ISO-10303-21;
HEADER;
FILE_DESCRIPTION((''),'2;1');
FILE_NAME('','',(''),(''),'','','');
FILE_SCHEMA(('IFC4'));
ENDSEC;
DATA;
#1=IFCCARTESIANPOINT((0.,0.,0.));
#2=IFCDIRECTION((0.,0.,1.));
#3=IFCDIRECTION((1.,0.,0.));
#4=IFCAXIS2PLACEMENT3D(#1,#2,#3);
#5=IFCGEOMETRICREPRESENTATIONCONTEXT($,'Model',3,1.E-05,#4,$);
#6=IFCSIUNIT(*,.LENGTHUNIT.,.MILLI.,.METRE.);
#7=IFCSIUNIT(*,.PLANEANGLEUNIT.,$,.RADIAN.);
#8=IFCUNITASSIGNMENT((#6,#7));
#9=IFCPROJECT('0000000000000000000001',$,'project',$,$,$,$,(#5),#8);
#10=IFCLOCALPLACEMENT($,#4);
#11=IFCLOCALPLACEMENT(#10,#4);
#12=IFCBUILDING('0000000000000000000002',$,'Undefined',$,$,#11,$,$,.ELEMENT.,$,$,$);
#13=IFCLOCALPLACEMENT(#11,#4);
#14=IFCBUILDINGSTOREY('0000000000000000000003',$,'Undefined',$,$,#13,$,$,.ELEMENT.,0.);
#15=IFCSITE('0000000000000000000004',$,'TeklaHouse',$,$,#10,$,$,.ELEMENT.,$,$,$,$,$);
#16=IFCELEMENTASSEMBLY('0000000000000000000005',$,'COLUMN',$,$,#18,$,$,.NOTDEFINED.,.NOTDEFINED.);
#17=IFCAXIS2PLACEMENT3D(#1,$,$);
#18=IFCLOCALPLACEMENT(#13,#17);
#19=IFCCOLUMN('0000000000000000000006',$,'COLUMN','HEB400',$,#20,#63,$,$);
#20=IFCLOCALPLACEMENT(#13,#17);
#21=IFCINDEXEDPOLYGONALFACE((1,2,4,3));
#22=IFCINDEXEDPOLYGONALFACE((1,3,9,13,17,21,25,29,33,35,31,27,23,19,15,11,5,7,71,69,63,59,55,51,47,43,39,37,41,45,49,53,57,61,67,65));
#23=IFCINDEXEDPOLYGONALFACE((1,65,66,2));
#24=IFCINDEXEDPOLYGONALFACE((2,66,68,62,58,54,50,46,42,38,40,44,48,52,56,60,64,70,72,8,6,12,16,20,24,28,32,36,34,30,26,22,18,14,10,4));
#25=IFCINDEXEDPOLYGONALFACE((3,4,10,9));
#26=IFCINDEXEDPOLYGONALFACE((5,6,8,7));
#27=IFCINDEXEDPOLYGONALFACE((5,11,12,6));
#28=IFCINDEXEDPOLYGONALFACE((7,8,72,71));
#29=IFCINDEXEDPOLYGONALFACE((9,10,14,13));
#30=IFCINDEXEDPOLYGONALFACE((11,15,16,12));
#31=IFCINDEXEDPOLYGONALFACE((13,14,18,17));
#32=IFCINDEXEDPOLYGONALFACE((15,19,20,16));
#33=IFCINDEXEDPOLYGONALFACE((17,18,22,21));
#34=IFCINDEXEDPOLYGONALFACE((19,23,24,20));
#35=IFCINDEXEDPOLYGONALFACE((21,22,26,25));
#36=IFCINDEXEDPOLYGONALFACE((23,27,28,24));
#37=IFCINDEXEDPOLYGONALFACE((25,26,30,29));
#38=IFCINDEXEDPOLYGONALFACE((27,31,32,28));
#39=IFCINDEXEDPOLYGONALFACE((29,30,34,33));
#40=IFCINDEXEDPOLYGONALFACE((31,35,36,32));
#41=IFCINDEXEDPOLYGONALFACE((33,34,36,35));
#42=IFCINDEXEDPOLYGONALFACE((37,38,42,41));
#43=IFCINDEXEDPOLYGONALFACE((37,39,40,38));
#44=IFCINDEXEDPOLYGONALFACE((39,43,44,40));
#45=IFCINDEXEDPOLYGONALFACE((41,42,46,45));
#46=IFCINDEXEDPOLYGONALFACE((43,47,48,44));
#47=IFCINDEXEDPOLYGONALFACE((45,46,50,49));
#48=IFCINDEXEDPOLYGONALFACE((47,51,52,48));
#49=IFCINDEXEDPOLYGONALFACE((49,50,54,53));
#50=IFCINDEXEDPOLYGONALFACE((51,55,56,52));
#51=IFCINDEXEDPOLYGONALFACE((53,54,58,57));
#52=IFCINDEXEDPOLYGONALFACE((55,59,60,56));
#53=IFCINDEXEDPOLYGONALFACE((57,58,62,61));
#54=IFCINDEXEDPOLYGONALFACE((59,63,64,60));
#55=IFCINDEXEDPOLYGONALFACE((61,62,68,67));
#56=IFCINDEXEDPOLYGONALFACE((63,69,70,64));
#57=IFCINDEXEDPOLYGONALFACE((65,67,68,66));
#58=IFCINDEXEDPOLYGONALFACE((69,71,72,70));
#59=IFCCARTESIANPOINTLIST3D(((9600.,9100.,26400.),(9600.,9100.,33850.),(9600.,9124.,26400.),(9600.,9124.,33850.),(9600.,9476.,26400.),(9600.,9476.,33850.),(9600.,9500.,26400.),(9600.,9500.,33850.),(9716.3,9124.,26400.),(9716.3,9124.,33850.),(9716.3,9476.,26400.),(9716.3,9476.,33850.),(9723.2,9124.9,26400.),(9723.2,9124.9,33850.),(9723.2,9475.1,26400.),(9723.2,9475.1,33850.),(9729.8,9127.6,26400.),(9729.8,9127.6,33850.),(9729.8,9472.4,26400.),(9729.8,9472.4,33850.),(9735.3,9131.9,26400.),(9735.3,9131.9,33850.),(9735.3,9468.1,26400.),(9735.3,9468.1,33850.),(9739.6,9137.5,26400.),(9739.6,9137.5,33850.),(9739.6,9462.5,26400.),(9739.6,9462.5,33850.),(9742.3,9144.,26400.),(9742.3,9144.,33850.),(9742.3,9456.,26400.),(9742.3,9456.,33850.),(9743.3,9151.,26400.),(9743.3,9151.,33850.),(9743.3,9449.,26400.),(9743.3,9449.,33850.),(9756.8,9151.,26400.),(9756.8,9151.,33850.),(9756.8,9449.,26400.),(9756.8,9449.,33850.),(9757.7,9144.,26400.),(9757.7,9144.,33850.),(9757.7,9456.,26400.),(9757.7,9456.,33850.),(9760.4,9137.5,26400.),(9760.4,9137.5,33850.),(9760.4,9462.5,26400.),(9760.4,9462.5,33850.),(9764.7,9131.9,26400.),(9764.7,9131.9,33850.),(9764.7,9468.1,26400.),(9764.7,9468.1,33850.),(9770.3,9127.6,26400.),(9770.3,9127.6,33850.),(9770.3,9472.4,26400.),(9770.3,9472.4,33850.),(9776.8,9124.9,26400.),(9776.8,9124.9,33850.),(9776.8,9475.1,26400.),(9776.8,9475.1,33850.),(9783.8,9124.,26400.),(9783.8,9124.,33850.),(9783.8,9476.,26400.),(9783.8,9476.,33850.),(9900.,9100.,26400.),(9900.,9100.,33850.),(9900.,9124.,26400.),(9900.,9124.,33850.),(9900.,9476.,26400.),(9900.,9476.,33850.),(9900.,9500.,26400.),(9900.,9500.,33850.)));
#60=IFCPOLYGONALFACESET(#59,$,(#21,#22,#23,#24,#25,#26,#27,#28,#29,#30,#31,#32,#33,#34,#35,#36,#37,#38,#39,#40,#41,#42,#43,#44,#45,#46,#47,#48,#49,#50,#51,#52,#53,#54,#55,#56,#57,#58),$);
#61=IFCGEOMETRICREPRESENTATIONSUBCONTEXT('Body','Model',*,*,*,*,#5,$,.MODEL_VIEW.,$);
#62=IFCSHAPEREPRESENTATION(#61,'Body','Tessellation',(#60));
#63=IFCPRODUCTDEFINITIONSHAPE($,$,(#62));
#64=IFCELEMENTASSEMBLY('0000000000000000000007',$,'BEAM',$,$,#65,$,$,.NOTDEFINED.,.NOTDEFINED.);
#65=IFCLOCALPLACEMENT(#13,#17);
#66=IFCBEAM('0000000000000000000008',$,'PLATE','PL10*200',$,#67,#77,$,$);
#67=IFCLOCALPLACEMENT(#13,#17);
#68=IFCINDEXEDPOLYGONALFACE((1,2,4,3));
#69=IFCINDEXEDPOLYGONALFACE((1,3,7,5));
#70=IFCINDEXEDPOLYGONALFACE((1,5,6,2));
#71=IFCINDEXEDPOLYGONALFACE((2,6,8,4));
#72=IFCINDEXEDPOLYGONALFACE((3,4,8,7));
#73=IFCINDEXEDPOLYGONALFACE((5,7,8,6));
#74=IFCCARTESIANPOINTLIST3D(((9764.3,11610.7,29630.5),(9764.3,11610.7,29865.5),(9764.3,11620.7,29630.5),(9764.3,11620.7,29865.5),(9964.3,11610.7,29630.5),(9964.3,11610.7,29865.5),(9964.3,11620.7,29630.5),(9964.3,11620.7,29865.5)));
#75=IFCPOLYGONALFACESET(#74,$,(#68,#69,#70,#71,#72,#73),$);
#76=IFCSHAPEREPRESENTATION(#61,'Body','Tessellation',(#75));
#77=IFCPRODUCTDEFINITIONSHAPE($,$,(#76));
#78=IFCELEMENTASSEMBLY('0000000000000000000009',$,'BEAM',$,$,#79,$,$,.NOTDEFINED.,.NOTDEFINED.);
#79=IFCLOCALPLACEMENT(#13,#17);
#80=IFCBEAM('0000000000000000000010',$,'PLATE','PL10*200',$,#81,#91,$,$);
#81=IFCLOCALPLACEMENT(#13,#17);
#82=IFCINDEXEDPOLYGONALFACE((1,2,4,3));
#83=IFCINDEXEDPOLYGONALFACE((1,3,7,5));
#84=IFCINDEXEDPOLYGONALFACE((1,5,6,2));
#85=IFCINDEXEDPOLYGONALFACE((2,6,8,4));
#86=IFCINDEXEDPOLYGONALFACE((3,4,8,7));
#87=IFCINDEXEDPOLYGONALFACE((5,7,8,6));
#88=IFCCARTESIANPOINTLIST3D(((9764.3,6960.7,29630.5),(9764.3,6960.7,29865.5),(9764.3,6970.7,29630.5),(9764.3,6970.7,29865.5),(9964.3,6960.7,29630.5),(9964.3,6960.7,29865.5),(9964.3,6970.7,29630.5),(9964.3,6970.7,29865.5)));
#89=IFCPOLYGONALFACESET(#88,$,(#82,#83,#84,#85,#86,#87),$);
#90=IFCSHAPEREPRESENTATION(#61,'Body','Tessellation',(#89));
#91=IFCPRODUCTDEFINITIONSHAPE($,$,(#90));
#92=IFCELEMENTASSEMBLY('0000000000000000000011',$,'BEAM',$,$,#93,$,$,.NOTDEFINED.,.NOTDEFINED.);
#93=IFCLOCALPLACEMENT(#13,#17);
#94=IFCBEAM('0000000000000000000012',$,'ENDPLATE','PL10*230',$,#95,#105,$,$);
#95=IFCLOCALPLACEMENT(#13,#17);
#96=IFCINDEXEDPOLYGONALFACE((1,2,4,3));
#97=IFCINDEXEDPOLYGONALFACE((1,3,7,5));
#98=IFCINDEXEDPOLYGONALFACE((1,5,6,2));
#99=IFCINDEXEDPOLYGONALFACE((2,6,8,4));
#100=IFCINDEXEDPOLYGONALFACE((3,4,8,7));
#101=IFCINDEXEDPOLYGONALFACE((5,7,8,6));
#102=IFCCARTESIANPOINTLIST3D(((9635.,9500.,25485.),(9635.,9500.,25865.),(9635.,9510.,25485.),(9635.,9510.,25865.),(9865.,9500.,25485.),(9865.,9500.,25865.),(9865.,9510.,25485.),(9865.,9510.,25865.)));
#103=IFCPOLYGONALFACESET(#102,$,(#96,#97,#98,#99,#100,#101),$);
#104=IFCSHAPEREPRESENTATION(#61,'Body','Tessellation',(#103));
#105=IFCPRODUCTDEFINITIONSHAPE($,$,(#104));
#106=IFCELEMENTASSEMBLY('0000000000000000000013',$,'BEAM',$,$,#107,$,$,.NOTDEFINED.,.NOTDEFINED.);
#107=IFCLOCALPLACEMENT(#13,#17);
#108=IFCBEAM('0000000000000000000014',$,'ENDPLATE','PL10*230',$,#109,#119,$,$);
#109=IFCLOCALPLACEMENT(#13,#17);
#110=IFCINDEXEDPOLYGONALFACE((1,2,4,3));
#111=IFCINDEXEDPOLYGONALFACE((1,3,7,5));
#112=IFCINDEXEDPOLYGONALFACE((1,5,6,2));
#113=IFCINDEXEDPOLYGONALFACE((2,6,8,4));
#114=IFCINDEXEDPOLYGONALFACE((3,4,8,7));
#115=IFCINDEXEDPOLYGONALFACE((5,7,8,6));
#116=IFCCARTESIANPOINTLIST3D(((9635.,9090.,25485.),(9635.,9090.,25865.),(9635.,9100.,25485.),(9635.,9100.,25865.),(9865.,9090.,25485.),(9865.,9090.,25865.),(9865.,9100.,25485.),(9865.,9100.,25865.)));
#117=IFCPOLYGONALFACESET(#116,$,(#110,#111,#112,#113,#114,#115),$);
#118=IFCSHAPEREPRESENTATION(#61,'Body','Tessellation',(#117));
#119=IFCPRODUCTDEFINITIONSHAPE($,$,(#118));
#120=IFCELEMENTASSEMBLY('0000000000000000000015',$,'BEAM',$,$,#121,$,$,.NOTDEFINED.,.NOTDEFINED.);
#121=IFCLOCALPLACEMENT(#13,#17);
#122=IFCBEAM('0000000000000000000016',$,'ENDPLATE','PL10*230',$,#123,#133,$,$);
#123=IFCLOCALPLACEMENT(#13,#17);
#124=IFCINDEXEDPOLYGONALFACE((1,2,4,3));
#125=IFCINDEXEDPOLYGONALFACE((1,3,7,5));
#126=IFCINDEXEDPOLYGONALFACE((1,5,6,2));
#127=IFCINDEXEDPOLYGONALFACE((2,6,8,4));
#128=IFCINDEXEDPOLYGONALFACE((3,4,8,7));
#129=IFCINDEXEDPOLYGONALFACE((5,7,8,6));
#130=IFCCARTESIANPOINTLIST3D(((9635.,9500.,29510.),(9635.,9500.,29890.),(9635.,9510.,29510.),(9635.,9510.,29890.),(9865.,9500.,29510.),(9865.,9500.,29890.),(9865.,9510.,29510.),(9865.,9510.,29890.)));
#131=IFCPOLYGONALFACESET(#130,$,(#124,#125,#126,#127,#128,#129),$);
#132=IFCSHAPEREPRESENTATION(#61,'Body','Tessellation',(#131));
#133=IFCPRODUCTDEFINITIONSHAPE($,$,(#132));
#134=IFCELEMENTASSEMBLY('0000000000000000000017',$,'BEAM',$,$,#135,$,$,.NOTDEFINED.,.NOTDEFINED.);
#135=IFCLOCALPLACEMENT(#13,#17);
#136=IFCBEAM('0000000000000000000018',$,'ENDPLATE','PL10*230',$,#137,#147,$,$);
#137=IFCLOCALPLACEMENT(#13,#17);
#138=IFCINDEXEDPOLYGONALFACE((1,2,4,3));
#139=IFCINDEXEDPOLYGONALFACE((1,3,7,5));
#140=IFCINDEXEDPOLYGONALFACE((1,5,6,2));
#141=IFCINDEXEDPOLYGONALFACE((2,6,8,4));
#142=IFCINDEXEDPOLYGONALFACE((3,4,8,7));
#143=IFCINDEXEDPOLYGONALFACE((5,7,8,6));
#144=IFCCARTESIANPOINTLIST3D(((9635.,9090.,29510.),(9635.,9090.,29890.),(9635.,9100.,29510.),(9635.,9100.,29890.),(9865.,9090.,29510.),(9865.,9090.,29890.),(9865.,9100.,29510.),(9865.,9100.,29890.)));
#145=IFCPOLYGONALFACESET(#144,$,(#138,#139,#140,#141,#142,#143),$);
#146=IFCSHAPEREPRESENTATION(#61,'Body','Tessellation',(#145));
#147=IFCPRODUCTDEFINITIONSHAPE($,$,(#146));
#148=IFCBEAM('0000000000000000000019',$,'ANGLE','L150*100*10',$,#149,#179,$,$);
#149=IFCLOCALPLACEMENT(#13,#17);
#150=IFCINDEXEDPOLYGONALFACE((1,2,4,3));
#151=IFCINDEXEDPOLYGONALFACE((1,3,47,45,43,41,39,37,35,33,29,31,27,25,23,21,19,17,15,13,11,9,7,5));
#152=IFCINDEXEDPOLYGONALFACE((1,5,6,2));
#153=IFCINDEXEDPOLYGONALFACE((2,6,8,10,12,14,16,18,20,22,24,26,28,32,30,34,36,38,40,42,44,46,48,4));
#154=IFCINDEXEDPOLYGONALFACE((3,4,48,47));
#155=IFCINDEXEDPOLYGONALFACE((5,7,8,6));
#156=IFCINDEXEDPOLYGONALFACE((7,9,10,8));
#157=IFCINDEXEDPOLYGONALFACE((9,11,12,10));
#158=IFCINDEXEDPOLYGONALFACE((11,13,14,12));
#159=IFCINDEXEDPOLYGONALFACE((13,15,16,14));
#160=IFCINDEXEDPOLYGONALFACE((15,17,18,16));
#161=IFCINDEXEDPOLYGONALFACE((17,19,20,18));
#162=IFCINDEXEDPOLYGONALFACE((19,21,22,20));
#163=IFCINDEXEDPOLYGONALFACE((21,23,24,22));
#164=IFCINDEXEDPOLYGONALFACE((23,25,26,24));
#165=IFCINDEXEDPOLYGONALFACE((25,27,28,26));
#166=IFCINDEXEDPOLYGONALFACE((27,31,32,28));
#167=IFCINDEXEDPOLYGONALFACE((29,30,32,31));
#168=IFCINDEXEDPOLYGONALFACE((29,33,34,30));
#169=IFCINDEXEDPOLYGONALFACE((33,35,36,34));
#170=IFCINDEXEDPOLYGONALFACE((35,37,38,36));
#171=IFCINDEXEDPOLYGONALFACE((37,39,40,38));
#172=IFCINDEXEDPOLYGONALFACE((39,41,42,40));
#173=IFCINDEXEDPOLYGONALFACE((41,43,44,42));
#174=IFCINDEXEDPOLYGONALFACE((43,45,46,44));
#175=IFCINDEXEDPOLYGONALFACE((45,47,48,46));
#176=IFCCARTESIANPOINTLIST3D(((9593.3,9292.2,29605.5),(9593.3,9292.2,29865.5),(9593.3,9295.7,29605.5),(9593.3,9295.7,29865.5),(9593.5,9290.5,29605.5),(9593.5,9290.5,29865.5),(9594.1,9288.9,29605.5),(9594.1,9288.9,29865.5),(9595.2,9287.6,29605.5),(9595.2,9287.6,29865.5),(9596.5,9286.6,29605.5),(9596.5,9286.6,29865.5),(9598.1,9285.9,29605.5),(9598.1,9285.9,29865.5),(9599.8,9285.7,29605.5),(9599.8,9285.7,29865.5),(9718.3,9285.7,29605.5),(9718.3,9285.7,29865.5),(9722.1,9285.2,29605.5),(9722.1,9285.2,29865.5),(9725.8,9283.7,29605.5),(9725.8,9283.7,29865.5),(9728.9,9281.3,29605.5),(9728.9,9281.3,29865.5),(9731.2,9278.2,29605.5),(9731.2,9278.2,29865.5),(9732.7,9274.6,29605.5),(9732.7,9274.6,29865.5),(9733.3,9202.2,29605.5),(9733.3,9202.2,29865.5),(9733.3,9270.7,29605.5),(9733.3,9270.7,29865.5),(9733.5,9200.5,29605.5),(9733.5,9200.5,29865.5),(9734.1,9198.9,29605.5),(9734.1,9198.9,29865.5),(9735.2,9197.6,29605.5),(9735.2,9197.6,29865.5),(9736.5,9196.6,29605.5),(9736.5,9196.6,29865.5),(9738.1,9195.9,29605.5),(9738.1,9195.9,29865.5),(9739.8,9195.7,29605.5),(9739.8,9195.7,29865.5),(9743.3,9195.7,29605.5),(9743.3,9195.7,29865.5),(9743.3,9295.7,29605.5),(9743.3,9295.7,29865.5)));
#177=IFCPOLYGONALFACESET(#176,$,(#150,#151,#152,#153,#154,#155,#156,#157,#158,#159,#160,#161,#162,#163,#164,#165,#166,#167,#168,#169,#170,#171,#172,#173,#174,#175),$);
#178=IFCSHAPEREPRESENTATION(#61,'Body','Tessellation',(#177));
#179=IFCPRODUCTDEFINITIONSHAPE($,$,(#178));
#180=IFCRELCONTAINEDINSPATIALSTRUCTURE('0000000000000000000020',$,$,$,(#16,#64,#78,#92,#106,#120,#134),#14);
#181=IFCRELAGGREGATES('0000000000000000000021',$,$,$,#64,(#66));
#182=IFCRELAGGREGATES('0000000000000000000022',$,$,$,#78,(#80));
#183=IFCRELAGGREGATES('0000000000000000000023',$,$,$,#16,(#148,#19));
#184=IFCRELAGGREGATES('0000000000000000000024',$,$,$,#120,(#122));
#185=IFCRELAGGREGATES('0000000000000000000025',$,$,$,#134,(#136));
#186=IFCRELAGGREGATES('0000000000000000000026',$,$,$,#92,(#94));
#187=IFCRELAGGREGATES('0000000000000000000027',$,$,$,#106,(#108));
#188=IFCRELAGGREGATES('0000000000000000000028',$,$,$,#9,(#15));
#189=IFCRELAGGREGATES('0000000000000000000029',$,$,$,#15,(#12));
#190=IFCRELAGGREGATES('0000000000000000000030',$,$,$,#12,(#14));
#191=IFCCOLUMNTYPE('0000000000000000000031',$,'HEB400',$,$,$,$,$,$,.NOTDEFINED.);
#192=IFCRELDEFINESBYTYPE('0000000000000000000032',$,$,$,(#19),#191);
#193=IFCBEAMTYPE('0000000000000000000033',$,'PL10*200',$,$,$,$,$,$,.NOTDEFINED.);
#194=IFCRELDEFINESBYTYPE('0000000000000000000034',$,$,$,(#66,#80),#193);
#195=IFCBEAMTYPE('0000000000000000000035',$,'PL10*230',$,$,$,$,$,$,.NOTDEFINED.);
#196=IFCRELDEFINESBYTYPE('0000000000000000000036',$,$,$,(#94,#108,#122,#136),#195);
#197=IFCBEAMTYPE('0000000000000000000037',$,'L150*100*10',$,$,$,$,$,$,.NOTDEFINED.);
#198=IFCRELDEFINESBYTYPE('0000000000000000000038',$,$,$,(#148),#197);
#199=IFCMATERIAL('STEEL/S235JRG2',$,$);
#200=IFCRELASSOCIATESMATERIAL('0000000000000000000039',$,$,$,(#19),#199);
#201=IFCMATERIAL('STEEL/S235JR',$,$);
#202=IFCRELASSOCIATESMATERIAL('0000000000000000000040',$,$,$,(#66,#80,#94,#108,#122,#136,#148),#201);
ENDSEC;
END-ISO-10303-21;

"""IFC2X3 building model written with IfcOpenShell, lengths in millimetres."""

from ifc_helpers import new_model, si_unit, frame, origin_with_axes, origin_2d_with_axis, place, context, subcontext, project, spatial, rectangle, i_section, l_section, extrude, material, type_object, element, aggregate, save


model = new_model("IFC2X3")

# Units and contexts
model_context = context("Model", 3, precision=1e-05, world=origin_with_axes())
body_context = subcontext(model_context, "Body", "Model", "MODEL_VIEW")
ifc_project = project(units=[si_unit("LENGTHUNIT", "METRE", prefix="MILLI"), si_unit("PLANEANGLEUNIT", "RADIAN")], contexts=[model_context])

# Site, building, storey
site_placement = place(None, origin_with_axes())
site = spatial("IfcSite", under=ifc_project, at=site_placement, Name="TeklaHouse", CompositionType="ELEMENT")
building_placement = place(site_placement, origin_with_axes())
building = spatial("IfcBuilding", under=site, at=building_placement, Name="Undefined", CompositionType="ELEMENT")
storey_placement = place(building_placement, origin_with_axes())
storey = spatial("IfcBuildingStorey", under=building, at=storey_placement, Name="Undefined", CompositionType="ELEMENT", Elevation=0.0)

# Element assembly, column
assembly_1_placement = place(storey_placement, origin_with_axes())
assembly_1 = element("IfcElementAssembly", 1, at=assembly_1_placement, inside=storey, Name="COLUMN", AssemblyPlace="NOTDEFINED", PredefinedType="NOTDEFINED")
ifc_material_1 = material(Name="STEEL/S235JRG2")
column_type = type_object("IfcColumnType", Name="HEB400", PredefinedType="NOTDEFINED")
column_placement = place(assembly_1_placement, frame((9750.0, 9300.0, 26400.0), z_axis=(0.0, 0.0, 1.0), x_axis=(0.0, 1.0, 0.0)))
column = element("IfcColumn", 2, at=column_placement, type_object=column_type, material=ifc_material_1, Name="COLUMN", Description="HEB400", context=body_context, shape_type="SweptSolid", body=[
    extrude(i_section(OverallWidth=300.0, OverallDepth=400.0, WebThickness=13.5, FlangeThickness=24.0, FilletRadius=27.0, at=origin_2d_with_axis()), frame((0.0, 0.0, 7450.0), z_axis=(0.0, 0.0, -1.0), x_axis=(0.0, 1.0, 0.0)), (0.0, 0.0, 1.0), 7450.0),
])

# Element assemblies, beams
assembly_2_placement = place(storey_placement, origin_with_axes())
assembly_2 = element("IfcElementAssembly", 3, at=assembly_2_placement, inside=storey, Name="BEAM", AssemblyPlace="NOTDEFINED", PredefinedType="NOTDEFINED")
ifc_material_2 = material(Name="STEEL/S235JR")
beam_type_1 = type_object("IfcBeamType", Name="PL10*200", PredefinedType="NOTDEFINED")
beam_1_placement = place(assembly_2_placement, frame((9864.3, 11615.7, 29630.5), z_axis=(-1.0, 0.0, 0.0), x_axis=(0.0, 0.0, 1.0)))
beam_1 = element("IfcBeam", 4, at=beam_1_placement, type_object=beam_type_1, material=ifc_material_2, Name="PLATE", Description="PL10*200", context=body_context, shape_type="SweptSolid", body=[
    extrude(rectangle(XDim=10.0, YDim=200.0, at=origin_2d_with_axis()), frame((235.0, 0.0, 0.0), z_axis=(-1.0, 0.0, 0.0), x_axis=(0.0, -1.0, 0.0)), (0.0, 0.0, 1.0), 235.0),
])
aggregate(assembly_2, [beam_1])
assembly_3_placement = place(storey_placement, origin_with_axes())
assembly_3 = element("IfcElementAssembly", 5, at=assembly_3_placement, inside=storey, Name="BEAM", AssemblyPlace="NOTDEFINED", PredefinedType="NOTDEFINED")
beam_2_placement = place(assembly_3_placement, frame((9864.3, 6965.7, 29630.5), z_axis=(-1.0, 0.0, 0.0), x_axis=(0.0, 0.0, 1.0)))
beam_2 = element("IfcBeam", 6, at=beam_2_placement, type_object=beam_type_1, material=ifc_material_2, Name="PLATE", Description="PL10*200", context=body_context, shape_type="SweptSolid", body=[
    extrude(rectangle(XDim=10.0, YDim=200.0, at=origin_2d_with_axis()), frame((235.0, 0.0, 0.0), z_axis=(-1.0, 0.0, 0.0), x_axis=(0.0, -1.0, 0.0)), (0.0, 0.0, 1.0), 235.0),
])
aggregate(assembly_3, [beam_2])
assembly_4_placement = place(storey_placement, origin_with_axes())
assembly_4 = element("IfcElementAssembly", 7, at=assembly_4_placement, inside=storey, Name="BEAM", AssemblyPlace="NOTDEFINED", PredefinedType="NOTDEFINED")
beam_type_2 = type_object("IfcBeamType", Name="PL10*230", PredefinedType="NOTDEFINED")
beam_3_placement = place(assembly_4_placement, frame((9750.0, 9505.0, 25485.0), z_axis=(1.0, 0.0, 0.0), x_axis=(0.0, 0.0, 1.0)))
beam_3 = element("IfcBeam", 8, at=beam_3_placement, type_object=beam_type_2, material=ifc_material_2, Name="ENDPLATE", Description="PL10*230", context=body_context, shape_type="SweptSolid", body=[
    extrude(rectangle(XDim=10.0, YDim=230.0, at=origin_2d_with_axis()), frame((380.0, 0.0, 0.0), z_axis=(-1.0, 0.0, 0.0), x_axis=(0.0, -1.0, 0.0)), (0.0, 0.0, 1.0), 380.0),
])
assembly_5_placement = place(storey_placement, origin_with_axes())
assembly_5 = element("IfcElementAssembly", 9, at=assembly_5_placement, inside=storey, Name="BEAM", AssemblyPlace="NOTDEFINED", PredefinedType="NOTDEFINED")
beam_4_placement = place(assembly_5_placement, frame((9750.0, 9095.0, 25485.0), z_axis=(-1.0, 0.0, 0.0), x_axis=(0.0, 0.0, 1.0)))
beam_4 = element("IfcBeam", 10, at=beam_4_placement, type_object=beam_type_2, material=ifc_material_2, Name="ENDPLATE", Description="PL10*230", context=body_context, shape_type="SweptSolid", body=[
    extrude(rectangle(XDim=10.0, YDim=230.0, at=origin_2d_with_axis()), frame((380.0, 0.0, 0.0), z_axis=(-1.0, 0.0, 0.0), x_axis=(0.0, -1.0, 0.0)), (0.0, 0.0, 1.0), 380.0),
])
assembly_6_placement = place(storey_placement, origin_with_axes())
assembly_6 = element("IfcElementAssembly", 11, at=assembly_6_placement, inside=storey, Name="BEAM", AssemblyPlace="NOTDEFINED", PredefinedType="NOTDEFINED")
beam_5_placement = place(assembly_6_placement, frame((9750.0, 9505.0, 29510.0), z_axis=(1.0, 0.0, 0.0), x_axis=(0.0, 0.0, 1.0)))
beam_5 = element("IfcBeam", 12, at=beam_5_placement, type_object=beam_type_2, material=ifc_material_2, Name="ENDPLATE", Description="PL10*230", context=body_context, shape_type="SweptSolid", body=[
    extrude(rectangle(XDim=10.0, YDim=230.0, at=origin_2d_with_axis()), frame((380.0, 0.0, 0.0), z_axis=(-1.0, 0.0, 0.0), x_axis=(0.0, -1.0, 0.0)), (0.0, 0.0, 1.0), 380.0),
])
assembly_7_placement = place(storey_placement, origin_with_axes())
assembly_7 = element("IfcElementAssembly", 13, at=assembly_7_placement, inside=storey, Name="BEAM", AssemblyPlace="NOTDEFINED", PredefinedType="NOTDEFINED")
beam_6_placement = place(assembly_7_placement, frame((9750.0, 9095.0, 29510.0), z_axis=(-1.0, 0.0, 0.0), x_axis=(0.0, 0.0, 1.0)))
beam_6 = element("IfcBeam", 14, at=beam_6_placement, type_object=beam_type_2, material=ifc_material_2, Name="ENDPLATE", Description="PL10*230", context=body_context, shape_type="SweptSolid", body=[
    extrude(rectangle(XDim=10.0, YDim=230.0, at=origin_2d_with_axis()), frame((380.0, 0.0, 0.0), z_axis=(-1.0, 0.0, 0.0), x_axis=(0.0, -1.0, 0.0)), (0.0, 0.0, 1.0), 380.0),
])

# Beam
beam_type_3 = type_object("IfcBeamType", Name="L150*100*10", PredefinedType="NOTDEFINED")
beam_7_placement = place(assembly_1_placement, frame((9668.3, 9245.7, 29605.5), z_axis=(-1.0, 0.0, 0.0), x_axis=(0.0, 0.0, 1.0)))
beam_7 = element("IfcBeam", 15, at=beam_7_placement, type_object=beam_type_3, material=ifc_material_2, Name="ANGLE", Description="L150*100*10", context=body_context, shape_type="SweptSolid", body=[
    extrude(l_section(Depth=150.0, Width=100.0, Thickness=10.0, FilletRadius=15.0, EdgeRadius=6.5, at=origin_2d_with_axis()), frame((260.0, 0.0, 0.0), z_axis=(-1.0, 0.0, 0.0), x_axis=(0.0, -1.0, 0.0)), (0.0, 0.0, 1.0), 260.0),
])
aggregate(assembly_1, [beam_7, column])

aggregate(assembly_6, [beam_5])
aggregate(assembly_7, [beam_6])

aggregate(assembly_4, [beam_3])
aggregate(assembly_5, [beam_4])

save(model, "model.ifc")
